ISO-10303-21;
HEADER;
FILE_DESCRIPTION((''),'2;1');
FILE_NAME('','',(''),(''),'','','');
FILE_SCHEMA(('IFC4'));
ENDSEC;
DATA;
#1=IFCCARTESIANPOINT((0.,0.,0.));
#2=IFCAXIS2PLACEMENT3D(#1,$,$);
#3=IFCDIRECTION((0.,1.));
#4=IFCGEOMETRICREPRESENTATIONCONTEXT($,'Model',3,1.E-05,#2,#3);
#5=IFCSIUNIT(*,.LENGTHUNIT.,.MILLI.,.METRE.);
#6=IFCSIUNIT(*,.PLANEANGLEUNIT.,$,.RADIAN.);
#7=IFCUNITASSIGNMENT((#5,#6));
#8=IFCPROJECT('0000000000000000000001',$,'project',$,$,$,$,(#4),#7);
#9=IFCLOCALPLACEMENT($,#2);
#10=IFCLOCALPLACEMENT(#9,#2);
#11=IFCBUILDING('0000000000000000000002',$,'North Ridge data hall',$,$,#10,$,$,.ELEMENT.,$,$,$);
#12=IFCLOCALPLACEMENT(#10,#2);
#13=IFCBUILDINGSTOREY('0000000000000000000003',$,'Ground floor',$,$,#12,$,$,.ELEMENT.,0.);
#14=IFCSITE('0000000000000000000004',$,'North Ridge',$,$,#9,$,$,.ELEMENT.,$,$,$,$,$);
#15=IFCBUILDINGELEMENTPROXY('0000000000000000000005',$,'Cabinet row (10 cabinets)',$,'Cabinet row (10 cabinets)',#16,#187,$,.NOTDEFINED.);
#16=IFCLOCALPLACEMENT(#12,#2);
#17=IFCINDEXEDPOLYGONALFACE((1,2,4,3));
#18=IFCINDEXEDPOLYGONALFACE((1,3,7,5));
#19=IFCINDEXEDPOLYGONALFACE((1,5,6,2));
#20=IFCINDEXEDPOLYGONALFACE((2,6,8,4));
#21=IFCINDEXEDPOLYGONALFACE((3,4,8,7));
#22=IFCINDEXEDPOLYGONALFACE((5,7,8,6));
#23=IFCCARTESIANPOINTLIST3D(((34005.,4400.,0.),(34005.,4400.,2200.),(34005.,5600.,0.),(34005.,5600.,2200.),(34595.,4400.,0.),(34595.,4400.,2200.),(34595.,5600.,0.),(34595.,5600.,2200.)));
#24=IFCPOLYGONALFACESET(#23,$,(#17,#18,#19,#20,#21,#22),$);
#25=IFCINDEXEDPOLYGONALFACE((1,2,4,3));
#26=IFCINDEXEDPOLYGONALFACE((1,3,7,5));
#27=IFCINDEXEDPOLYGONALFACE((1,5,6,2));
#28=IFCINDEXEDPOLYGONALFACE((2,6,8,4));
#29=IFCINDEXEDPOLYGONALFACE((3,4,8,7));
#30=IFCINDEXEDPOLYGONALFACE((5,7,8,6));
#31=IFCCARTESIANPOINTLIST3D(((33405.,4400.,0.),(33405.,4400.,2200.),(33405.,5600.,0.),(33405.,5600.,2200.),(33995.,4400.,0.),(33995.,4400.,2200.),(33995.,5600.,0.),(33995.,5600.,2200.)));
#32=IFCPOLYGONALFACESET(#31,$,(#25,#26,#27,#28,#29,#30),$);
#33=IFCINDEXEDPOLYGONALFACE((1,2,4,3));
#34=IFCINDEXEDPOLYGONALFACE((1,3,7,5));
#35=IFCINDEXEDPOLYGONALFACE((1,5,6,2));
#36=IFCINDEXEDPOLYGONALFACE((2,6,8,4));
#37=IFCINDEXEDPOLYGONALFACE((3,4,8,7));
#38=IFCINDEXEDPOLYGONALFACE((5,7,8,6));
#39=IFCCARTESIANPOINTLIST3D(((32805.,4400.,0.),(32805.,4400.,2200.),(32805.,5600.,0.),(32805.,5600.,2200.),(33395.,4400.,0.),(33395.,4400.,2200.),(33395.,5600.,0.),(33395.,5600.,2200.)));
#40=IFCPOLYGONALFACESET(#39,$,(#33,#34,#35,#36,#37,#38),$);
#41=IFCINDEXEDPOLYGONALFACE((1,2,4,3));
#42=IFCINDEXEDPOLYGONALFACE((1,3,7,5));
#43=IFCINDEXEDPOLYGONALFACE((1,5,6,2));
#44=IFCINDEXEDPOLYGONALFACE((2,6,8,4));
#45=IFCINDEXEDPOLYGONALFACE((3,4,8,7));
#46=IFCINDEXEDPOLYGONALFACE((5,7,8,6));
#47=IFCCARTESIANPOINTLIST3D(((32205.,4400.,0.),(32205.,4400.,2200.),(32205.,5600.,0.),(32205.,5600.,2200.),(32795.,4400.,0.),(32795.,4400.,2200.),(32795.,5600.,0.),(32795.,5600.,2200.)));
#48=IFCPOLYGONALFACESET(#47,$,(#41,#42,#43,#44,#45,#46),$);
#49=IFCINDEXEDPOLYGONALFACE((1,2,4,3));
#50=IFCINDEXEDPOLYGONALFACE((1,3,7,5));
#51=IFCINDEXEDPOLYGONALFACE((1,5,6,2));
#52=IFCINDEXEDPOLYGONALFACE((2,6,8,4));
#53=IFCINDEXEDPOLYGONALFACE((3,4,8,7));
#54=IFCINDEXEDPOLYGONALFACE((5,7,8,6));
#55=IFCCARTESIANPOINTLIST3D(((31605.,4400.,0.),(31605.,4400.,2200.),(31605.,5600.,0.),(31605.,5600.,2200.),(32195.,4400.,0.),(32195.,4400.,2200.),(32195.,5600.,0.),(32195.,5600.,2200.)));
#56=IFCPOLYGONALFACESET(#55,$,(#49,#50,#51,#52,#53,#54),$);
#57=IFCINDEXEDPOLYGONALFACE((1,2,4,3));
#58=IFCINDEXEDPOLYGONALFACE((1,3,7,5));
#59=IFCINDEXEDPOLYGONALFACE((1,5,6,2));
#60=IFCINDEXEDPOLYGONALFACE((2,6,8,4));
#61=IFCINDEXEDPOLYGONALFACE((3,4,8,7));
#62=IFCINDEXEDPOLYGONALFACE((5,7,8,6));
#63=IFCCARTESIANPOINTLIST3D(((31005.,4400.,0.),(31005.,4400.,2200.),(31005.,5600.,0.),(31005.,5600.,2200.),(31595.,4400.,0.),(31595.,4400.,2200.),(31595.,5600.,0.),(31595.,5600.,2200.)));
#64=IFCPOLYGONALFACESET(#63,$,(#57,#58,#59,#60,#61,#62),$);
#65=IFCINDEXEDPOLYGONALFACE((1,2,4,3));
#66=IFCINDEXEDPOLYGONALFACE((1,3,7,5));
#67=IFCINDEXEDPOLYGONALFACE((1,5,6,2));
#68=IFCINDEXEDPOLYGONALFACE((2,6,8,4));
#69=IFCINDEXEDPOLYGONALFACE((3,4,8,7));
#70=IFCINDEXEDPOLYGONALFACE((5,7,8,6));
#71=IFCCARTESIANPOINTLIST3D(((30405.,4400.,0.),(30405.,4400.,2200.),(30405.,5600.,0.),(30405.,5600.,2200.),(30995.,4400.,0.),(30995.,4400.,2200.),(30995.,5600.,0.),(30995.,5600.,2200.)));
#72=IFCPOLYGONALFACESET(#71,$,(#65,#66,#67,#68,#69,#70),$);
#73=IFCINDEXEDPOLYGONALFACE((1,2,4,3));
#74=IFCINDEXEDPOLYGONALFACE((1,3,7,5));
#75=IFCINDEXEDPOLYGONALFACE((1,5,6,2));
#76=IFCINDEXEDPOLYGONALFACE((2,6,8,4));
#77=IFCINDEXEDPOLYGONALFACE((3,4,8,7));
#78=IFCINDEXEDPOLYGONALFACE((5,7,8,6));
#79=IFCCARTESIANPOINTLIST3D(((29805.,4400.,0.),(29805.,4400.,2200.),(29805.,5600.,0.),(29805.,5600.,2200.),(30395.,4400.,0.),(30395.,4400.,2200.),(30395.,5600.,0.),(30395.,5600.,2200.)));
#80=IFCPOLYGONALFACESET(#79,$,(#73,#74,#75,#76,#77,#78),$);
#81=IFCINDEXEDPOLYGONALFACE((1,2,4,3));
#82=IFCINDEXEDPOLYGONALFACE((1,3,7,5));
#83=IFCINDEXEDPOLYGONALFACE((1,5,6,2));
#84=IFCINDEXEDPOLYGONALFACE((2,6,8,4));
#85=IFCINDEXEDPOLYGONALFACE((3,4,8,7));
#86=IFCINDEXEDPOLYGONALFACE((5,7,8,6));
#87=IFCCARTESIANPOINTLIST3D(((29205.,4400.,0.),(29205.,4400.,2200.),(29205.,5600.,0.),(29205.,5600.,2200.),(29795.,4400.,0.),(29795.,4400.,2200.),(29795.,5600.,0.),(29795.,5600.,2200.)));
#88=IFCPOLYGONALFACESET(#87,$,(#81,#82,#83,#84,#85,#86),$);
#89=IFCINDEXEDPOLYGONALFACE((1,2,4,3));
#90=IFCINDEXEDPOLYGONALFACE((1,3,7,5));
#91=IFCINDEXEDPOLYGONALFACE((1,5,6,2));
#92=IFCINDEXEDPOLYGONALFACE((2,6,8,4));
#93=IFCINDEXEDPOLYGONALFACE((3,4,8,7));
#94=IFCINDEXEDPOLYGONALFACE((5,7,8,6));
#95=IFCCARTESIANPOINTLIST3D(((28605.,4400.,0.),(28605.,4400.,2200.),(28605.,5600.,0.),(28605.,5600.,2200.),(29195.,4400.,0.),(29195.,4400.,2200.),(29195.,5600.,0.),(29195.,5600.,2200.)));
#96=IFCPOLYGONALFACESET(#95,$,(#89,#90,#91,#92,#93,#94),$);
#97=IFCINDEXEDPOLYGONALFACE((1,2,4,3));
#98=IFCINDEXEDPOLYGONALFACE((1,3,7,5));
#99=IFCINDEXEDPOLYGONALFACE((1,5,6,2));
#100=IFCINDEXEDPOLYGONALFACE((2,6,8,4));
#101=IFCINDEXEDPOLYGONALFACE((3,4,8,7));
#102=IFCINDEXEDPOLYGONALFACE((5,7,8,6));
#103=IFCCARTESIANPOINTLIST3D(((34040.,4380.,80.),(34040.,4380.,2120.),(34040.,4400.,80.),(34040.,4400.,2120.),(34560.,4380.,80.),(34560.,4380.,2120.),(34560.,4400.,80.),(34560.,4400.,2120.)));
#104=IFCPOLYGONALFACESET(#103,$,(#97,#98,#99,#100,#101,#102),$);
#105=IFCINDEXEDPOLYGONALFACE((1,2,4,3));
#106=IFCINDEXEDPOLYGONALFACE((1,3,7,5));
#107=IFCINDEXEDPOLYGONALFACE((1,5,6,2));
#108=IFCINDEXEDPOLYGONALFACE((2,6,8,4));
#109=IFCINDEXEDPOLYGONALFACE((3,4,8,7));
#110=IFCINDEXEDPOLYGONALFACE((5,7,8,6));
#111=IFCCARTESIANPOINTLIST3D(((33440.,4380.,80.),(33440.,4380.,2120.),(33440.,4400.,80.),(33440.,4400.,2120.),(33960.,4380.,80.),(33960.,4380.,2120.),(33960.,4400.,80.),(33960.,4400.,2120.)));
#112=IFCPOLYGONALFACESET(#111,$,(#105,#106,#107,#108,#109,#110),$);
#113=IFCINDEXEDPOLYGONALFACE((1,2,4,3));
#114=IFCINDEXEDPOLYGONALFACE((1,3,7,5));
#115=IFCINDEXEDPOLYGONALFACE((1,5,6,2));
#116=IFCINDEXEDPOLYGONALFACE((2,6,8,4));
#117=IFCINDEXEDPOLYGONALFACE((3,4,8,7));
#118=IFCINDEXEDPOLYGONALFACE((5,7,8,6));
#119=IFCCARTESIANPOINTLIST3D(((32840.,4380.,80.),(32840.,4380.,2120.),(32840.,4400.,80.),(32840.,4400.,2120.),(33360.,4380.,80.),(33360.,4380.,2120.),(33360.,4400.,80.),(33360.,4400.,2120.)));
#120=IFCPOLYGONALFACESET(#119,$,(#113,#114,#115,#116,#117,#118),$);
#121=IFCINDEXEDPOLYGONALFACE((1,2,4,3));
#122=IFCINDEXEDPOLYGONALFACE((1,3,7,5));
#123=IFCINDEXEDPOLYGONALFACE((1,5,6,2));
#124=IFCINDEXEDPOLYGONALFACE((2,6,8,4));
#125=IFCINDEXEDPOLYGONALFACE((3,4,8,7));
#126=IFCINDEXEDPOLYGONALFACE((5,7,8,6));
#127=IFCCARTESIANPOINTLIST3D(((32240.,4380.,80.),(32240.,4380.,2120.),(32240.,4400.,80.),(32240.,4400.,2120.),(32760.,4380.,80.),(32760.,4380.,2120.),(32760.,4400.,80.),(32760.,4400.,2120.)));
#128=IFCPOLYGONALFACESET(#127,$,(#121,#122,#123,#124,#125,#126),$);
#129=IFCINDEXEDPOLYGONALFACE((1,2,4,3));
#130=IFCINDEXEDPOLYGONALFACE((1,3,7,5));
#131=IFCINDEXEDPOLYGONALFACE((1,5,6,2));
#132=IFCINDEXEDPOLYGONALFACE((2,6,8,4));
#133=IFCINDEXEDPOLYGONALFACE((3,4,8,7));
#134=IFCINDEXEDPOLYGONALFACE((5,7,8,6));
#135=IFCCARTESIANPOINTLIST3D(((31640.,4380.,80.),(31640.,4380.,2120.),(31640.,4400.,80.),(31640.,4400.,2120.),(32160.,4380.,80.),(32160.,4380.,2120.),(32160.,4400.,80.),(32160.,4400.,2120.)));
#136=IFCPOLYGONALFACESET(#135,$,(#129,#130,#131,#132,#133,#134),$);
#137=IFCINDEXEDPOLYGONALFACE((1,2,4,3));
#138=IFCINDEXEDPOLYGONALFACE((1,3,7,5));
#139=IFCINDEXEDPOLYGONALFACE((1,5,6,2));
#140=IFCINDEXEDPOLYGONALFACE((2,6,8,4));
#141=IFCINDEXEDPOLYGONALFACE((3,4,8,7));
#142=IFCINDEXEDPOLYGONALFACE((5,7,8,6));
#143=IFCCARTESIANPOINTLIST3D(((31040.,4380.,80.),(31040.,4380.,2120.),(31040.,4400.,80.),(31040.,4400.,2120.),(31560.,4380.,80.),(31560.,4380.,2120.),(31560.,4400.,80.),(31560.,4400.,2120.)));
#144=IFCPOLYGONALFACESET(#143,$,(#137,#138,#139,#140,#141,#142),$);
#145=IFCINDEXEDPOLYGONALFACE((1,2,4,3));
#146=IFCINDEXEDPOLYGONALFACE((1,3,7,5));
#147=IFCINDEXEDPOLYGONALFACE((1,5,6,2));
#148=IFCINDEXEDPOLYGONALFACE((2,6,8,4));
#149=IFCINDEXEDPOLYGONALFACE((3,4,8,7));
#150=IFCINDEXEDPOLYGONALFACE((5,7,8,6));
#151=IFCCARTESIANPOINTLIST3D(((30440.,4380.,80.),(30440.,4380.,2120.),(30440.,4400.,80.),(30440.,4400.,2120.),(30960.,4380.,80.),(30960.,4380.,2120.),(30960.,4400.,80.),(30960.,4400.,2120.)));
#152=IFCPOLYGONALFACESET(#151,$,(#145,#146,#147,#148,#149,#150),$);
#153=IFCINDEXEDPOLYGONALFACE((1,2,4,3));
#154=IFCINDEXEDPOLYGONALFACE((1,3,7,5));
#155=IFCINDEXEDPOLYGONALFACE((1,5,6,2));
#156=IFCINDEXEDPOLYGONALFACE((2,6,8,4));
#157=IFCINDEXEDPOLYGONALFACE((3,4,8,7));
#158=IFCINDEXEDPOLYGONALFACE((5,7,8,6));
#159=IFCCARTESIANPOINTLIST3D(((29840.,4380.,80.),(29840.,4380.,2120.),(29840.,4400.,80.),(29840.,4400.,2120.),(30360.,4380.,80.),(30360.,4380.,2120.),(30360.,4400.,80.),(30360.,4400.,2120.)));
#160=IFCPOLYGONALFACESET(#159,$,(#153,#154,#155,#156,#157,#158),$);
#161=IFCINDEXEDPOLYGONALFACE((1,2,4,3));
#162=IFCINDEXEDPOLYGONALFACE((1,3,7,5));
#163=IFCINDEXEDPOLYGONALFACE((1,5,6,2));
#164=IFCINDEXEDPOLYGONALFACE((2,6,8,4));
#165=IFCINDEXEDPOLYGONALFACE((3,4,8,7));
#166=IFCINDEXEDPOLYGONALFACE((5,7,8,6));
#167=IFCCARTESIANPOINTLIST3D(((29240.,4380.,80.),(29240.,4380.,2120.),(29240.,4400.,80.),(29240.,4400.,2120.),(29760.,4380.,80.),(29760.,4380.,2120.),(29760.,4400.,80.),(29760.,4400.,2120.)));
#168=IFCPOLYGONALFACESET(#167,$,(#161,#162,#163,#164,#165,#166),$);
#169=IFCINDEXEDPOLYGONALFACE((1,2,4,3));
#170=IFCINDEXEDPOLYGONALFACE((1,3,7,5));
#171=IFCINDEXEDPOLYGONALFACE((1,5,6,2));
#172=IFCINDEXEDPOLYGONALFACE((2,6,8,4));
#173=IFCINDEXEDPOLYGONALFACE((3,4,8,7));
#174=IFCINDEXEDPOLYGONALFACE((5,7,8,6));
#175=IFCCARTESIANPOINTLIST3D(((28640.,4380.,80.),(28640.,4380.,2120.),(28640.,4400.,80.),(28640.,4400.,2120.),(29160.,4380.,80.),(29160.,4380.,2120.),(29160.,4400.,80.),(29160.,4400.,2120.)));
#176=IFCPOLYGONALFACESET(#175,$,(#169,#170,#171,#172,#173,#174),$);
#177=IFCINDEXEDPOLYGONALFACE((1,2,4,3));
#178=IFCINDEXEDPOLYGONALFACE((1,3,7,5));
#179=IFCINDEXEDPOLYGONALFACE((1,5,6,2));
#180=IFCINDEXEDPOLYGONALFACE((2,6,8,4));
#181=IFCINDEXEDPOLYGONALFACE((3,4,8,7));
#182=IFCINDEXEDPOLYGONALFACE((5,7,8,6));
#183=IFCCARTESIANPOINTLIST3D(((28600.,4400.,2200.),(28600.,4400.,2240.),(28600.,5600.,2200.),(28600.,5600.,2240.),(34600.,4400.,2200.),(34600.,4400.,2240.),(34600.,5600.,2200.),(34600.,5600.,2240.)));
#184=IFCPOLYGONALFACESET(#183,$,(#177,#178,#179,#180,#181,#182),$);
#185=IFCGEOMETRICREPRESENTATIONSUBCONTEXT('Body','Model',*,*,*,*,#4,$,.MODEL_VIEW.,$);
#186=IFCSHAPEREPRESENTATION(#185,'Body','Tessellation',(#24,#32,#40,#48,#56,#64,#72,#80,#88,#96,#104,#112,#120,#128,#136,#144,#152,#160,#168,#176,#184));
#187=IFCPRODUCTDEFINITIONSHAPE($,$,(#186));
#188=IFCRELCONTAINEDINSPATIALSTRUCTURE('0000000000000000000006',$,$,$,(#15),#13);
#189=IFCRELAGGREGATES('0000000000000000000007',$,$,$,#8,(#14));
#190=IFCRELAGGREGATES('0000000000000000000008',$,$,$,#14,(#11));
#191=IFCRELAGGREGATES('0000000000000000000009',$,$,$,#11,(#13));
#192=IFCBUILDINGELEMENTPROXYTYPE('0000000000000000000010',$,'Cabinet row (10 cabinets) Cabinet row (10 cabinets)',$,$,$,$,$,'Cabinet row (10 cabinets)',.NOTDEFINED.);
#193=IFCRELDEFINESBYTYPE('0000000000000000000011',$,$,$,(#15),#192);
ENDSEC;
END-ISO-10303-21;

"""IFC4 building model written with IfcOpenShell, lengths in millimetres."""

from ifc_helpers import new_model, si_unit, direction, frame, origin, place, context, subcontext, project, spatial, polyline, outline, extrude, source, transform, mapped, type_object, type_shapes, element, save


model = new_model("IFC4")

# Units and contexts
model_context = context("Model", 3, precision=1e-05, world=origin(), true_north=direction((0.0, 1.0)))
body_context = subcontext(model_context, "Body", "Model", "MODEL_VIEW")
ifc_project = project(units=[si_unit("LENGTHUNIT", "METRE", prefix="MILLI"), si_unit("PLANEANGLEUNIT", "RADIAN")], contexts=[model_context])

# Site, building, storey
site_placement = place(None, origin())
site = spatial("IfcSite", under=ifc_project, at=site_placement, Name="North Ridge", CompositionType="ELEMENT")
building_placement = place(site_placement, origin())
building = spatial("IfcBuilding", under=site, at=building_placement, Name="North Ridge data hall", CompositionType="ELEMENT")
storey_placement = place(building_placement, origin())
storey = spatial("IfcBuildingStorey", under=building, at=storey_placement, Name="Ground floor", CompositionType="ELEMENT", Elevation=0.0)

# Building element proxy
building_element_proxy_type_1 = type_object("IfcBuildingElementProxyType", Name="Cabinet row (10 cabinets) Cabinet row (10 cabinets)", ElementType="Cabinet row (10 cabinets)", PredefinedType="NOTDEFINED")
shared_shape_1 = source(origin(), body_context, "Body", "SweptSolid", [
    extrude(outline(polyline([(5.0, 0.0), (595.0, 0.0), (595.0, 1200.0), (5.0, 1200.0), (5.0, 0.0)])), origin(), (0.0, 0.0, 1.0), 2200.0),
    extrude(outline(polyline([(605.0, 0.0), (1195.0, 0.0), (1195.0, 1200.0), (605.0, 1200.0), (605.0, 0.0)])), origin(), (0.0, 0.0, 1.0), 2200.0),
    extrude(outline(polyline([(1205.0, 0.0), (1795.0, 0.0), (1795.0, 1200.0), (1205.0, 1200.0), (1205.0, 0.0)])), origin(), (0.0, 0.0, 1.0), 2200.0),
    extrude(outline(polyline([(1805.0, 0.0), (2395.0, 0.0), (2395.0, 1200.0), (1805.0, 1200.0), (1805.0, 0.0)])), origin(), (0.0, 0.0, 1.0), 2200.0),
    extrude(outline(polyline([(2405.0, 0.0), (2995.0, 0.0), (2995.0, 1200.0), (2405.0, 1200.0), (2405.0, 0.0)])), origin(), (0.0, 0.0, 1.0), 2200.0),
    extrude(outline(polyline([(3005.0, 0.0), (3595.0, 0.0), (3595.0, 1200.0), (3005.0, 1200.0), (3005.0, 0.0)])), origin(), (0.0, 0.0, 1.0), 2200.0),
    extrude(outline(polyline([(3605.0, 0.0), (4195.0, 0.0), (4195.0, 1200.0), (3605.0, 1200.0), (3605.0, 0.0)])), origin(), (0.0, 0.0, 1.0), 2200.0),
    extrude(outline(polyline([(4205.0, 0.0), (4795.0, 0.0), (4795.0, 1200.0), (4205.0, 1200.0), (4205.0, 0.0)])), origin(), (0.0, 0.0, 1.0), 2200.0),
    extrude(outline(polyline([(4805.0, 0.0), (5395.0, 0.0), (5395.0, 1200.0), (4805.0, 1200.0), (4805.0, 0.0)])), origin(), (0.0, 0.0, 1.0), 2200.0),
    extrude(outline(polyline([(5405.0, 0.0), (5995.0, 0.0), (5995.0, 1200.0), (5405.0, 1200.0), (5405.0, 0.0)])), origin(), (0.0, 0.0, 1.0), 2200.0),
    extrude(outline(polyline([(40.0, 1200.0), (560.0, 1200.0), (560.0, 1220.0), (40.0, 1220.0), (40.0, 1200.0)])), frame((0.0, 0.0, 80.0)), (0.0, 0.0, 1.0), 2040.0),
    extrude(outline(polyline([(640.0, 1200.0), (1160.0, 1200.0), (1160.0, 1220.0), (640.0, 1220.0), (640.0, 1200.0)])), frame((0.0, 0.0, 80.0)), (0.0, 0.0, 1.0), 2040.0),
    extrude(outline(polyline([(1240.0, 1200.0), (1760.0, 1200.0), (1760.0, 1220.0), (1240.0, 1220.0), (1240.0, 1200.0)])), frame((0.0, 0.0, 80.0)), (0.0, 0.0, 1.0), 2040.0),
    extrude(outline(polyline([(1840.0, 1200.0), (2360.0, 1200.0), (2360.0, 1220.0), (1840.0, 1220.0), (1840.0, 1200.0)])), frame((0.0, 0.0, 80.0)), (0.0, 0.0, 1.0), 2040.0),
    extrude(outline(polyline([(2440.0, 1200.0), (2960.0, 1200.0), (2960.0, 1220.0), (2440.0, 1220.0), (2440.0, 1200.0)])), frame((0.0, 0.0, 80.0)), (0.0, 0.0, 1.0), 2040.0),
    extrude(outline(polyline([(3040.0, 1200.0), (3560.0, 1200.0), (3560.0, 1220.0), (3040.0, 1220.0), (3040.0, 1200.0)])), frame((0.0, 0.0, 80.0)), (0.0, 0.0, 1.0), 2040.0),
    extrude(outline(polyline([(3640.0, 1200.0), (4160.0, 1200.0), (4160.0, 1220.0), (3640.0, 1220.0), (3640.0, 1200.0)])), frame((0.0, 0.0, 80.0)), (0.0, 0.0, 1.0), 2040.0),
    extrude(outline(polyline([(4240.0, 1200.0), (4760.0, 1200.0), (4760.0, 1220.0), (4240.0, 1220.0), (4240.0, 1200.0)])), frame((0.0, 0.0, 80.0)), (0.0, 0.0, 1.0), 2040.0),
    extrude(outline(polyline([(4840.0, 1200.0), (5360.0, 1200.0), (5360.0, 1220.0), (4840.0, 1220.0), (4840.0, 1200.0)])), frame((0.0, 0.0, 80.0)), (0.0, 0.0, 1.0), 2040.0),
    extrude(outline(polyline([(5440.0, 1200.0), (5960.0, 1200.0), (5960.0, 1220.0), (5440.0, 1220.0), (5440.0, 1200.0)])), frame((0.0, 0.0, 80.0)), (0.0, 0.0, 1.0), 2040.0),
    extrude(outline(polyline([(0.0, 0.0), (6000.0, 0.0), (6000.0, 1200.0), (0.0, 1200.0), (0.0, 0.0)])), frame((0.0, 0.0, 2200.0)), (0.0, 0.0, 1.0), 40.0),
])
type_shapes(building_element_proxy_type_1, [shared_shape_1])
for number, where, z_axis, x_axis, name in (
    (1, (34600.0, 5600.0, 0.0), (0.0, 0.0, 1.0), (-1.0, 0.0, 0.0), "Cabinet row (10 cabinets)"),
):
    element("IfcBuildingElementProxy", number, at=place(storey_placement, frame(where, z_axis=z_axis, x_axis=x_axis)), inside=storey, type_object=building_element_proxy_type_1, Name=name, ObjectType="Cabinet row (10 cabinets)", PredefinedType="NOTDEFINED", context=body_context, shape_type="MappedRepresentation", body=[
        mapped(shared_shape_1, transform((0.0, 0.0, 0.0))),
    ])

save(model, "model.ifc")
